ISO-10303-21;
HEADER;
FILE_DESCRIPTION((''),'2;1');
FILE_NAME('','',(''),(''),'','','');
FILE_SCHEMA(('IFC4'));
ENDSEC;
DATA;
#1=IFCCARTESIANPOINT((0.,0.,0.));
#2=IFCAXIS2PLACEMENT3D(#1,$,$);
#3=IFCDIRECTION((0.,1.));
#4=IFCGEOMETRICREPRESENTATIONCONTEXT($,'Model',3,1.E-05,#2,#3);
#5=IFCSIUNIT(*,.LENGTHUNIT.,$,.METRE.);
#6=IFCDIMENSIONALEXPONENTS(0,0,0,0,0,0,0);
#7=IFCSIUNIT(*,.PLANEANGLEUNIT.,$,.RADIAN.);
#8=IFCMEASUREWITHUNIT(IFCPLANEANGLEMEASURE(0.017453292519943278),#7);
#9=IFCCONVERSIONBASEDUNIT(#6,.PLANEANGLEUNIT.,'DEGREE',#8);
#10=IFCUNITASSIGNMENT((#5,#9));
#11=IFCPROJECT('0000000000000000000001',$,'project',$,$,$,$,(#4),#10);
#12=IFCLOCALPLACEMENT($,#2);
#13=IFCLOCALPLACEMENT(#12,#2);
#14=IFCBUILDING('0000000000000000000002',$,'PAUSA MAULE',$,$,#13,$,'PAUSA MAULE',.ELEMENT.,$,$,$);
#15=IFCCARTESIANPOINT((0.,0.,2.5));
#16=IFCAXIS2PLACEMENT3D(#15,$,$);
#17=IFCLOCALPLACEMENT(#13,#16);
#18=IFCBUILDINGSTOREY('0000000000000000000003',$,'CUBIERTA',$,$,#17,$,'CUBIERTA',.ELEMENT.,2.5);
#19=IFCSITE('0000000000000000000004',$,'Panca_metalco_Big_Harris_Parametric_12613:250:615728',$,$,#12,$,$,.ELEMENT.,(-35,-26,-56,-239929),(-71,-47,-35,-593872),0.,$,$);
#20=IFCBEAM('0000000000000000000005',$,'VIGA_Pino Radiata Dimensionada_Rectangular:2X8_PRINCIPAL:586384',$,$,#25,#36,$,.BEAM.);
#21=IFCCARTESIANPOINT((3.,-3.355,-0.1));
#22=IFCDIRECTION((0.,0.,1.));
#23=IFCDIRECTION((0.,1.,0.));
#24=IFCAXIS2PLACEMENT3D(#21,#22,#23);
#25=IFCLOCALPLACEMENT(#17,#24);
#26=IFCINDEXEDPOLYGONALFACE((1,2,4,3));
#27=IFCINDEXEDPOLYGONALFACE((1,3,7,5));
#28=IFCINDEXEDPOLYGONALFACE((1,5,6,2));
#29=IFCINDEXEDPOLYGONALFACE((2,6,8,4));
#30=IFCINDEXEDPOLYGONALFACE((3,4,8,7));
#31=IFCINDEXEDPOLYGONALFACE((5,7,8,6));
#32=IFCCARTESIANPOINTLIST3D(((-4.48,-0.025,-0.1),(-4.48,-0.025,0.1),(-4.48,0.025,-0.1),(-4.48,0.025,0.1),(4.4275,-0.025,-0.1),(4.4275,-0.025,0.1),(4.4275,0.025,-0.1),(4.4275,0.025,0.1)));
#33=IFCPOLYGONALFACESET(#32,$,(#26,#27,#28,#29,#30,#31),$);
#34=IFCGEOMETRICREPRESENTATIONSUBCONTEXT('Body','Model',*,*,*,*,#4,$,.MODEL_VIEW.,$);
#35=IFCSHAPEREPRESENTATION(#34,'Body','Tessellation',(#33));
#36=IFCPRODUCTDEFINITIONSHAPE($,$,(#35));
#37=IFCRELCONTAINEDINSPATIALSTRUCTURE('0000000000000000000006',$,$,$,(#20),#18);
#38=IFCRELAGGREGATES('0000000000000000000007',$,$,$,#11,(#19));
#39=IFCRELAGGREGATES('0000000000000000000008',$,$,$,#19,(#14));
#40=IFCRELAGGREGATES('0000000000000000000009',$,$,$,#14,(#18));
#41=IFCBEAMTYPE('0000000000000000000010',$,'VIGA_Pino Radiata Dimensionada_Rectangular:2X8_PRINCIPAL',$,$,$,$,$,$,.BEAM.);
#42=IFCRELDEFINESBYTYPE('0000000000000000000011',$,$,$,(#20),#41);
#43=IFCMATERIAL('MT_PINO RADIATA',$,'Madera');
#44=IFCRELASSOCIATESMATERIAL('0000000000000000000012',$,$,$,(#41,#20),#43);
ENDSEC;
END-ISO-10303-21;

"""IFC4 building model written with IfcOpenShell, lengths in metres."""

from ifc_helpers import new_model, entity, si_unit, converted_unit, direction, frame, origin, origin_2d_with_axis, place, context, subcontext, project, spatial, rectangle, extrude, source, transform, mapped, material, material_profile, profile_set, profile_usage, type_object, type_shapes, element, save


model = new_model("IFC4")

# Units and contexts
model_context = context("Model", 3, precision=1e-05, world=origin(), true_north=direction((0.0, 1.0)))
body_context = subcontext(model_context, "Body", "Model", "MODEL_VIEW")
ifc_project = project(units=[si_unit("LENGTHUNIT", "METRE"), converted_unit("PLANEANGLEUNIT", "DEGREE", entity("IfcPlaneAngleMeasure", 0.017453292519943278), si_unit("PLANEANGLEUNIT", "RADIAN"), dimensions=[0, 0, 0, 0, 0, 0, 0])], contexts=[model_context])

# Site, building, storey
site_placement = place(None, origin())
site = spatial("IfcSite", under=ifc_project, at=site_placement, Name="Panca_metalco_Big_Harris_Parametric_12613:250:615728", CompositionType="ELEMENT", RefLatitude=(-35, -26, -56, -239929), RefLongitude=(-71, -47, -35, -593872), RefElevation=0.0)
building_placement = place(site_placement, origin())
building = spatial("IfcBuilding", under=site, at=building_placement, Name="PAUSA MAULE", LongName="PAUSA MAULE", CompositionType="ELEMENT")
storey_placement = place(building_placement, frame((0.0, 0.0, 2.5)))
storey = spatial("IfcBuildingStorey", under=building, at=storey_placement, Name="CUBIERTA", LongName="CUBIERTA", CompositionType="ELEMENT", Elevation=2.5)

# Beam
ifc_material_1 = material(Name="MT_PINO RADIATA", Category="Madera")
ifc_material_profile_1 = material_profile(ifc_material_1, rectangle(XDim=8.87, YDim=0.05, at=origin_2d_with_axis()), Name="2X8_PRINCIPAL")
ifc_profile_set_1 = profile_set([ifc_material_profile_1], Name="2X8_PRINCIPAL")
ifc_profile_usage_1 = profile_usage(ifc_profile_set_1, cardinal=8)
beam_type_1 = type_object("IfcBeamType", Name="VIGA_Pino Radiata Dimensionada_Rectangular:2X8_PRINCIPAL", PredefinedType="BEAM", material=ifc_profile_set_1)
shared_shape_1 = source(origin(), body_context, "Body", "SweptSolid", [
    extrude(rectangle(XDim=8.9075, YDim=0.05, at=origin_2d_with_axis()), frame((-0.0262, 0.0, -0.1), z_axis=(0.0, 0.0, 1.0), x_axis=(-1.0, 0.0, 0.0)), (0.0, 0.0, 1.0), 0.2),
])
type_shapes(beam_type_1, [shared_shape_1])
beam_1_placement = place(storey_placement, frame((3.0, -3.355, -0.1), z_axis=(0.0, 0.0, 1.0), x_axis=(0.0, 1.0, 0.0)))
element("IfcBeam", 1, at=beam_1_placement, inside=storey, type_object=beam_type_1, material=ifc_profile_usage_1, Name="VIGA_Pino Radiata Dimensionada_Rectangular:2X8_PRINCIPAL:586384", PredefinedType="BEAM", context=body_context, shape_type="MappedRepresentation", body=[
    mapped(shared_shape_1, transform((0.0, 0.0, 0.0), scale=1.0)),
])

save(model, "model.ifc")
